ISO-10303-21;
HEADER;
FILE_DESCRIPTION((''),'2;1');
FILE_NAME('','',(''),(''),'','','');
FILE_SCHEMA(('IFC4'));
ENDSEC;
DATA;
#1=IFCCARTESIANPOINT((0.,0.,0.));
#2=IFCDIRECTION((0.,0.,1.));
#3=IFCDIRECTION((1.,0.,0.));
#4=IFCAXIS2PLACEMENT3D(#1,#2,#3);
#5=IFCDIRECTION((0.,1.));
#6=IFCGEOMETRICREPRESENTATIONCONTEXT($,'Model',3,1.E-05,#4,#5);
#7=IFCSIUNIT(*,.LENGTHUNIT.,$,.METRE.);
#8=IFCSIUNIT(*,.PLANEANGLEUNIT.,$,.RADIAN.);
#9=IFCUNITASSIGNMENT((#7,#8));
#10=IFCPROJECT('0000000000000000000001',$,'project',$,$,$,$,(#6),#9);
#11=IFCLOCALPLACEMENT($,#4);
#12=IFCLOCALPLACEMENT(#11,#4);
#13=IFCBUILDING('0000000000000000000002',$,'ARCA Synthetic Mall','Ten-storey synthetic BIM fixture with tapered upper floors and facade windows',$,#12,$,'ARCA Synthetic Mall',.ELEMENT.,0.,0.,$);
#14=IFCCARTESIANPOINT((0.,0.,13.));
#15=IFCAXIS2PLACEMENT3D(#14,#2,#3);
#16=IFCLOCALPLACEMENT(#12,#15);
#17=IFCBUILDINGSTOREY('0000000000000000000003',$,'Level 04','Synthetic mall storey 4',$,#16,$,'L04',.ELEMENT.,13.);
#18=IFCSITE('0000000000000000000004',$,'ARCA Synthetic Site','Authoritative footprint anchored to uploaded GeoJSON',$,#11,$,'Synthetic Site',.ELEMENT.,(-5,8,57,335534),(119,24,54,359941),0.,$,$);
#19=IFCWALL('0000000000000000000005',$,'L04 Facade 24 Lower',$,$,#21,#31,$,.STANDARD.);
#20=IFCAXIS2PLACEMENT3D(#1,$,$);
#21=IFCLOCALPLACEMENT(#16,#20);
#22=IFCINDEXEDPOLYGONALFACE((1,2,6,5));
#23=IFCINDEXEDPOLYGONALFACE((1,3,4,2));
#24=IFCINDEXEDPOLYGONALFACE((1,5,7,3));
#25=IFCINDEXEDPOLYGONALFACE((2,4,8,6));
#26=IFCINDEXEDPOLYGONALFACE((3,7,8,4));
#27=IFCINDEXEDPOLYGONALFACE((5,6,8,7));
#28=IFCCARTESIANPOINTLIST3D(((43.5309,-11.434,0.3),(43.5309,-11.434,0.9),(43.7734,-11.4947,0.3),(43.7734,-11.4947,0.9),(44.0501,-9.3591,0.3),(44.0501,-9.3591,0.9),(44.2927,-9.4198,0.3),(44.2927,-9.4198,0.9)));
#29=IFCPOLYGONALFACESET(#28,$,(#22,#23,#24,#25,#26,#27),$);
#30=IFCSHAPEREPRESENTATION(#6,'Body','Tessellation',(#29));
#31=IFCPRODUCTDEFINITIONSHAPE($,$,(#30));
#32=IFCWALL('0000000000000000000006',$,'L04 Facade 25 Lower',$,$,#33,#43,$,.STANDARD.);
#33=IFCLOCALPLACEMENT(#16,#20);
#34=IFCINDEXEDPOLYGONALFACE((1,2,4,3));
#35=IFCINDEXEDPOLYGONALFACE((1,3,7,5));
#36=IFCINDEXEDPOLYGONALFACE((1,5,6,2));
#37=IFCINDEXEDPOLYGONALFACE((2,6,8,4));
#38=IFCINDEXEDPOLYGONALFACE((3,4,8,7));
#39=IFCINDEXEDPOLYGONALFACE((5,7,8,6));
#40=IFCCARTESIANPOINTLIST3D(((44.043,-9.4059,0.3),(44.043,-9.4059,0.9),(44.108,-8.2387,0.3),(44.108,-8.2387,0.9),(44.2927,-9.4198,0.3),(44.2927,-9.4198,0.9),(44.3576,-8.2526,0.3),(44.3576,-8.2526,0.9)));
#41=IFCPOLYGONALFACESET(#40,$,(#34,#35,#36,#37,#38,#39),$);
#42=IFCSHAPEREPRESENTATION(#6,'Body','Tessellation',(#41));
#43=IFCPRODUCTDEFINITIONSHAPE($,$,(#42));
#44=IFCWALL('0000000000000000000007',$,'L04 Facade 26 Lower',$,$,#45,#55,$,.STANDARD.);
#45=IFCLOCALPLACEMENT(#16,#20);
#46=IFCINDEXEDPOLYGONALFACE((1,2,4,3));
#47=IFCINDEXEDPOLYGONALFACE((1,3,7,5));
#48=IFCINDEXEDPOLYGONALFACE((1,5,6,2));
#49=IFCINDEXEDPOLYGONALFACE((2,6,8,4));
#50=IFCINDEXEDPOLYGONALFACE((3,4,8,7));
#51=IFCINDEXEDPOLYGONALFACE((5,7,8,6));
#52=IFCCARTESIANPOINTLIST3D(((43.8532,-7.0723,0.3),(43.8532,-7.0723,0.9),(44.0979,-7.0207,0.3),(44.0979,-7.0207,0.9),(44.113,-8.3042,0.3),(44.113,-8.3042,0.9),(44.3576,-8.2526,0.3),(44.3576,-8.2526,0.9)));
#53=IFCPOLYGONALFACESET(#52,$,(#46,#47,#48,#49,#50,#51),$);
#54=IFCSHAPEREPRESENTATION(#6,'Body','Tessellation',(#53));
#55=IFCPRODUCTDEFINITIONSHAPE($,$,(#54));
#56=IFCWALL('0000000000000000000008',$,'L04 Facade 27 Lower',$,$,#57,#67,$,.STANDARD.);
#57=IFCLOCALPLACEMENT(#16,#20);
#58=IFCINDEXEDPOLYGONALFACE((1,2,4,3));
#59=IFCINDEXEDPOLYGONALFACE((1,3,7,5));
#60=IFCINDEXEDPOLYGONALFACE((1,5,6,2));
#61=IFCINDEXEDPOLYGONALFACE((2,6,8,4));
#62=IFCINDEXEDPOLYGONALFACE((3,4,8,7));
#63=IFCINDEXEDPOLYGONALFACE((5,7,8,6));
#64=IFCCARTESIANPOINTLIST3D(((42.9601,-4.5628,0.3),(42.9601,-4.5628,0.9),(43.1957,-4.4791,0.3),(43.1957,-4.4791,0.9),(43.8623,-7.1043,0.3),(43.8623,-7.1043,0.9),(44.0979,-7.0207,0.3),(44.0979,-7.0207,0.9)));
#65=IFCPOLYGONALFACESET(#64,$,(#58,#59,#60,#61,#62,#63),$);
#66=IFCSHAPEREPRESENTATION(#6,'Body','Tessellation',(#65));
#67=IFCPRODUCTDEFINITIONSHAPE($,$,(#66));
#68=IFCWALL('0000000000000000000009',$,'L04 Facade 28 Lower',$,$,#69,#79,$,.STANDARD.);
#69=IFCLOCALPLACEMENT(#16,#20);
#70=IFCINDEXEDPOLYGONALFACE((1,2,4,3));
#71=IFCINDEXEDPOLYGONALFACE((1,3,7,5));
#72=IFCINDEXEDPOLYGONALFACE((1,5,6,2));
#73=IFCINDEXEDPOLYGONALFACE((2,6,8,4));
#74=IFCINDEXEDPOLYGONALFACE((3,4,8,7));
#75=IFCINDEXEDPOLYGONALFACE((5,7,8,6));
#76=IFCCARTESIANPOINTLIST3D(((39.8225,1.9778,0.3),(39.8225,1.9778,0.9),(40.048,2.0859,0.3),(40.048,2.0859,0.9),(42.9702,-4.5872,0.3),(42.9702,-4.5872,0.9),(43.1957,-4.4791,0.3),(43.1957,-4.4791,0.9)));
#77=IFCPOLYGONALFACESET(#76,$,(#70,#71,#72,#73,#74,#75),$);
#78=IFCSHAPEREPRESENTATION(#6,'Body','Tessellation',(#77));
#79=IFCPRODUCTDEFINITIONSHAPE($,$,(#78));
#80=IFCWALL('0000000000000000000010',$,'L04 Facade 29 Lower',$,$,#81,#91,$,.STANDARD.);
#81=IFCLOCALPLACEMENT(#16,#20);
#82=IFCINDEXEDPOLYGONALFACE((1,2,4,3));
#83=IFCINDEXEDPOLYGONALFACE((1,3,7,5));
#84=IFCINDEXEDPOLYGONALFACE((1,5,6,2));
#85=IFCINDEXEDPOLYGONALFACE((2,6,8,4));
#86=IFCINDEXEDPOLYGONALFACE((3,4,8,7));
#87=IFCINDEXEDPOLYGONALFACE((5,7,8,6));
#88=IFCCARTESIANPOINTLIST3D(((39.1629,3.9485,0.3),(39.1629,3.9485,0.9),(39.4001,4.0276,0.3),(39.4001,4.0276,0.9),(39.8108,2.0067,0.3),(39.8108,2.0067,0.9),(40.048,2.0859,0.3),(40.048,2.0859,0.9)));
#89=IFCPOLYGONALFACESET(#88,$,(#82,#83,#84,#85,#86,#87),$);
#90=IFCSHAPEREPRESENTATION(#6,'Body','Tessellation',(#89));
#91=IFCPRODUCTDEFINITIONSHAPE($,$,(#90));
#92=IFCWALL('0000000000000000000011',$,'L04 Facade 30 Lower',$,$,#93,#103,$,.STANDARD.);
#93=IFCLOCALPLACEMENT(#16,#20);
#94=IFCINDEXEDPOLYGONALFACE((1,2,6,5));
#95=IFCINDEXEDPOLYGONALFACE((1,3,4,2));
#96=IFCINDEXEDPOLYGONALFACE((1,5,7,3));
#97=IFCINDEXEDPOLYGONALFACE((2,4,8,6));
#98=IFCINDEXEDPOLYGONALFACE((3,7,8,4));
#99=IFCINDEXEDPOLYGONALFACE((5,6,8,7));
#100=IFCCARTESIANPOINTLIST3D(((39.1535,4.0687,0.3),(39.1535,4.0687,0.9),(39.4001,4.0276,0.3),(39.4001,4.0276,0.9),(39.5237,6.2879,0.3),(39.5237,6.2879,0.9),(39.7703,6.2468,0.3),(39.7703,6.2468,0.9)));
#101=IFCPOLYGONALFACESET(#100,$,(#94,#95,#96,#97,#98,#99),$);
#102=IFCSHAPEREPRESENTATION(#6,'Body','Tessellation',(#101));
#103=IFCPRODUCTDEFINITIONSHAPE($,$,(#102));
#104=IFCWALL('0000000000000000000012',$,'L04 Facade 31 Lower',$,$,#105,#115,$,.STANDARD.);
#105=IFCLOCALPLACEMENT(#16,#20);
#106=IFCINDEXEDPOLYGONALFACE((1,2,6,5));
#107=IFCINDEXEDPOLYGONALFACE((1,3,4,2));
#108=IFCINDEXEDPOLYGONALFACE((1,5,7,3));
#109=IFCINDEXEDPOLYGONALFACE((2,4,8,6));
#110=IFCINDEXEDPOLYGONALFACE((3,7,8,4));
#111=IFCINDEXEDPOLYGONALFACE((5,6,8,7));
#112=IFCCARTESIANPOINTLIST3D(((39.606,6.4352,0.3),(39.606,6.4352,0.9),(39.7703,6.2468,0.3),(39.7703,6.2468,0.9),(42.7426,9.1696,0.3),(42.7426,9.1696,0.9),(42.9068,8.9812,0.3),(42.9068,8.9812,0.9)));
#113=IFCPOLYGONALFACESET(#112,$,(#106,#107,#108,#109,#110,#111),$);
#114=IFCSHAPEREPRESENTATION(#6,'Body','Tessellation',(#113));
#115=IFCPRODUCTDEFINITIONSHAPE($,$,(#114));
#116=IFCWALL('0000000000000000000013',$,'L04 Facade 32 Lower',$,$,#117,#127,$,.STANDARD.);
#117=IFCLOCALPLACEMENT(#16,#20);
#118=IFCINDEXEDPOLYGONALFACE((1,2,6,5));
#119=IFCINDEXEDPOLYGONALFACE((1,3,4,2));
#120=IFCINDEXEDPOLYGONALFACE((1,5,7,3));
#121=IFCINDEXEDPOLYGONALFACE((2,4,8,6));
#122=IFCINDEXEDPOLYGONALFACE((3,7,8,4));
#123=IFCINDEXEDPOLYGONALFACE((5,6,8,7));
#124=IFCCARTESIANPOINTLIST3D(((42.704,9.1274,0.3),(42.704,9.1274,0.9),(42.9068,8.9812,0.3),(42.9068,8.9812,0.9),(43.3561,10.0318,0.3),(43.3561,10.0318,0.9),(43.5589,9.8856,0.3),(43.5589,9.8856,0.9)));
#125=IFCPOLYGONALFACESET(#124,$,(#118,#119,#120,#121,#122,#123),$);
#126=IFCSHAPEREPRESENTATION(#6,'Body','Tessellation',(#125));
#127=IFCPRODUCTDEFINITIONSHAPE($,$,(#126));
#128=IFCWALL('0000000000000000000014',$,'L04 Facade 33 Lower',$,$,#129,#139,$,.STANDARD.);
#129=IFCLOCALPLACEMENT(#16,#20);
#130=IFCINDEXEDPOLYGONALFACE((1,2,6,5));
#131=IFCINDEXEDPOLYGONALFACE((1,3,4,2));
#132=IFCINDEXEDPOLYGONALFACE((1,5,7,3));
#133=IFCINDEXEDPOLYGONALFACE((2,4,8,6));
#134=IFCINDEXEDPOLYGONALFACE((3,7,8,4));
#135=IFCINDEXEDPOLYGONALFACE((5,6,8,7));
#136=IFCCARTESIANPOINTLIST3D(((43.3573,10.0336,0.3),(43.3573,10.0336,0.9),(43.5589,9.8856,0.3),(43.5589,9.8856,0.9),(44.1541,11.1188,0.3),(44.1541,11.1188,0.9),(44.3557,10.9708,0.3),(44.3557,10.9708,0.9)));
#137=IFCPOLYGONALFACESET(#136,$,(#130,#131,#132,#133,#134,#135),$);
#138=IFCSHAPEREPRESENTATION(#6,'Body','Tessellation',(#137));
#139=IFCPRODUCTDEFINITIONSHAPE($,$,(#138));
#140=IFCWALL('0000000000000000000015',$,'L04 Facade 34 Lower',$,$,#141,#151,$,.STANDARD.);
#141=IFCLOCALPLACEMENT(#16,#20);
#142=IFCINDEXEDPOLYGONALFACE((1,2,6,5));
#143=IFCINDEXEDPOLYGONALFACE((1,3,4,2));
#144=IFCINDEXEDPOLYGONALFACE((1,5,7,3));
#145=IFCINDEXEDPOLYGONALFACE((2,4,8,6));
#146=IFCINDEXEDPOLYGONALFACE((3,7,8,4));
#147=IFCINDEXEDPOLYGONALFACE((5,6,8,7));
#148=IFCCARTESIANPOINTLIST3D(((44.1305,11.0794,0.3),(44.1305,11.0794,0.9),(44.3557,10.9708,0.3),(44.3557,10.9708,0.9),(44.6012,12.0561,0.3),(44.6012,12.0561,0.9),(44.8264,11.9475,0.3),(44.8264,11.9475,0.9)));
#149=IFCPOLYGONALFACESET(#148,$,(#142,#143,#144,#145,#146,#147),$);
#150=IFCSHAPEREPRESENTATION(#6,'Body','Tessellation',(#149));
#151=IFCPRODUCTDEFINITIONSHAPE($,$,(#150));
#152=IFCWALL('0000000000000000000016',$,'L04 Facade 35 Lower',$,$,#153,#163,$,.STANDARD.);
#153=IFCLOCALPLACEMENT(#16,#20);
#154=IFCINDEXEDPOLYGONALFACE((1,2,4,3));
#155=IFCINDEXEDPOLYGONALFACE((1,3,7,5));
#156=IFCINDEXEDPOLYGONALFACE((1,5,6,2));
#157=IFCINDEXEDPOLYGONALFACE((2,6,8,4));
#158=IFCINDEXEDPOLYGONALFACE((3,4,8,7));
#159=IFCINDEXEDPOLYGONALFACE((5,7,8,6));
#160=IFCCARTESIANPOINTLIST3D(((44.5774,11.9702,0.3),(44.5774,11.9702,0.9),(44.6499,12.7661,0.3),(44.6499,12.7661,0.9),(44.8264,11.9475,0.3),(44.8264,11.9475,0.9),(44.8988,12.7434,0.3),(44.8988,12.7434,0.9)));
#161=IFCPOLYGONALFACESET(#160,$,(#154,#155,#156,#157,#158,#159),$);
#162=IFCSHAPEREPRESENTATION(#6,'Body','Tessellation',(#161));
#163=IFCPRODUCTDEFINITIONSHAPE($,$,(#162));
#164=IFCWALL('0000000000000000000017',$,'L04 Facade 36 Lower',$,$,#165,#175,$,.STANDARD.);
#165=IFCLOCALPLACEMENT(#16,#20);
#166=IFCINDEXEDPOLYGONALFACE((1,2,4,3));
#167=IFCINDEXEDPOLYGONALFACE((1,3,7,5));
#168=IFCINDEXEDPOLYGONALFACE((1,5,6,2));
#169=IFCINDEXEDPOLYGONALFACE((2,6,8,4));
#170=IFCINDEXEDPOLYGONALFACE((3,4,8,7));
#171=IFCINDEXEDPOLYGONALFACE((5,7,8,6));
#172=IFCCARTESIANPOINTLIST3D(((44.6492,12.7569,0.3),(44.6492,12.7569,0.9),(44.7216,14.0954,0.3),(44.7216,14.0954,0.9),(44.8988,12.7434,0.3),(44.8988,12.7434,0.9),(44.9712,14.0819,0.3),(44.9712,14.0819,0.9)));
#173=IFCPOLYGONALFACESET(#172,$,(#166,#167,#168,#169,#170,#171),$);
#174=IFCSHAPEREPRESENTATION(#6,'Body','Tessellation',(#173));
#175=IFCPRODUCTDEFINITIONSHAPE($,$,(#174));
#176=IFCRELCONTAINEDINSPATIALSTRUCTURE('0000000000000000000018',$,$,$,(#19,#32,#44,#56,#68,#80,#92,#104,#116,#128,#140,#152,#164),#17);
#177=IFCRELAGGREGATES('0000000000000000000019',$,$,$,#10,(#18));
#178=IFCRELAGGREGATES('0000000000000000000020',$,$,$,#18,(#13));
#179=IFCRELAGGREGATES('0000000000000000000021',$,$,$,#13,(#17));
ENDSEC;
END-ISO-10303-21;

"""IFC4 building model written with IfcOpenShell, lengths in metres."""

from ifc_helpers import new_model, si_unit, direction, frame, origin_with_axes, place, context, project, spatial, polyline, outline, extrude, element, save


model = new_model("IFC4")

# Units and contexts
model_context = context("Model", 3, precision=1e-05, world=origin_with_axes(), true_north=direction((0.0, 1.0)))
ifc_project = project(units=[si_unit("LENGTHUNIT", "METRE"), si_unit("PLANEANGLEUNIT", "RADIAN")], contexts=[model_context])

# Site, building, storey
site_placement = place(None, origin_with_axes())
site = spatial("IfcSite", under=ifc_project, at=site_placement, Name="ARCA Synthetic Site", Description="Authoritative footprint anchored to uploaded GeoJSON", LongName="Synthetic Site", CompositionType="ELEMENT", RefLatitude=(-5, 8, 57, 335534), RefLongitude=(119, 24, 54, 359941), RefElevation=0.0)
building_placement = place(site_placement, origin_with_axes())
building = spatial("IfcBuilding", under=site, at=building_placement, Name="ARCA Synthetic Mall", Description="Ten-storey synthetic BIM fixture with tapered upper floors and facade windows", LongName="ARCA Synthetic Mall", CompositionType="ELEMENT", ElevationOfRefHeight=0.0, ElevationOfTerrain=0.0)
storey_placement = place(building_placement, frame((0.0, 0.0, 13.0), z_axis=(0.0, 0.0, 1.0), x_axis=(1.0, 0.0, 0.0)))
storey = spatial("IfcBuildingStorey", under=building, at=storey_placement, Name="Level 04", Description="Synthetic mall storey 4", LongName="L04", CompositionType="ELEMENT", Elevation=13.0)

# Walls
wall_1_placement = place(storey_placement, frame((0.0, 0.0, 0.3), z_axis=(0.0, 0.0, 1.0), x_axis=(1.0, 0.0, 0.0)))
element("IfcWall", 1, at=wall_1_placement, inside=storey, Name="L04 Facade 24 Lower", PredefinedType="STANDARD", context=model_context, shape_type="SweptSolid", body=[
    extrude(outline(polyline([(43.7734, -11.4947), (44.2927, -9.4198), (44.0501, -9.3591), (43.5309, -11.434), (43.7734, -11.4947)])), origin_with_axes(), (0.0, 0.0, 1.0), 0.6),
])
wall_2_placement = place(storey_placement, frame((0.0, 0.0, 0.3), z_axis=(0.0, 0.0, 1.0), x_axis=(1.0, 0.0, 0.0)))
element("IfcWall", 2, at=wall_2_placement, inside=storey, Name="L04 Facade 25 Lower", PredefinedType="STANDARD", context=model_context, shape_type="SweptSolid", body=[
    extrude(outline(polyline([(44.2927, -9.4198), (44.3576, -8.2526), (44.108, -8.2387), (44.043, -9.4059), (44.2927, -9.4198)])), origin_with_axes(), (0.0, 0.0, 1.0), 0.6),
])
wall_3_placement = place(storey_placement, frame((0.0, 0.0, 0.3), z_axis=(0.0, 0.0, 1.0), x_axis=(1.0, 0.0, 0.0)))
element("IfcWall", 3, at=wall_3_placement, inside=storey, Name="L04 Facade 26 Lower", PredefinedType="STANDARD", context=model_context, shape_type="SweptSolid", body=[
    extrude(outline(polyline([(44.3576, -8.2526), (44.0979, -7.0207), (43.8532, -7.0723), (44.113, -8.3042), (44.3576, -8.2526)])), origin_with_axes(), (0.0, 0.0, 1.0), 0.6),
])
wall_4_placement = place(storey_placement, frame((0.0, 0.0, 0.3), z_axis=(0.0, 0.0, 1.0), x_axis=(1.0, 0.0, 0.0)))
element("IfcWall", 4, at=wall_4_placement, inside=storey, Name="L04 Facade 27 Lower", PredefinedType="STANDARD", context=model_context, shape_type="SweptSolid", body=[
    extrude(outline(polyline([(44.0979, -7.0207), (43.1957, -4.4791), (42.9601, -4.5628), (43.8623, -7.1043), (44.0979, -7.0207)])), origin_with_axes(), (0.0, 0.0, 1.0), 0.6),
])
wall_5_placement = place(storey_placement, frame((0.0, 0.0, 0.3), z_axis=(0.0, 0.0, 1.0), x_axis=(1.0, 0.0, 0.0)))
element("IfcWall", 5, at=wall_5_placement, inside=storey, Name="L04 Facade 28 Lower", PredefinedType="STANDARD", context=model_context, shape_type="SweptSolid", body=[
    extrude(outline(polyline([(43.1957, -4.4791), (40.048, 2.0859), (39.8225, 1.9778), (42.9702, -4.5872), (43.1957, -4.4791)])), origin_with_axes(), (0.0, 0.0, 1.0), 0.6),
])
wall_6_placement = place(storey_placement, frame((0.0, 0.0, 0.3), z_axis=(0.0, 0.0, 1.0), x_axis=(1.0, 0.0, 0.0)))
element("IfcWall", 6, at=wall_6_placement, inside=storey, Name="L04 Facade 29 Lower", PredefinedType="STANDARD", context=model_context, shape_type="SweptSolid", body=[
    extrude(outline(polyline([(40.048, 2.0859), (39.4001, 4.0276), (39.1629, 3.9485), (39.8108, 2.0067), (40.048, 2.0859)])), origin_with_axes(), (0.0, 0.0, 1.0), 0.6),
])
wall_7_placement = place(storey_placement, frame((0.0, 0.0, 0.3), z_axis=(0.0, 0.0, 1.0), x_axis=(1.0, 0.0, 0.0)))
element("IfcWall", 7, at=wall_7_placement, inside=storey, Name="L04 Facade 30 Lower", PredefinedType="STANDARD", context=model_context, shape_type="SweptSolid", body=[
    extrude(outline(polyline([(39.4001, 4.0276), (39.7703, 6.2468), (39.5237, 6.2879), (39.1535, 4.0687), (39.4001, 4.0276)])), origin_with_axes(), (0.0, 0.0, 1.0), 0.6),
])
wall_8_placement = place(storey_placement, frame((0.0, 0.0, 0.3), z_axis=(0.0, 0.0, 1.0), x_axis=(1.0, 0.0, 0.0)))
element("IfcWall", 8, at=wall_8_placement, inside=storey, Name="L04 Facade 31 Lower", PredefinedType="STANDARD", context=model_context, shape_type="SweptSolid", body=[
    extrude(outline(polyline([(39.7703, 6.2468), (42.9068, 8.9812), (42.7426, 9.1696), (39.606, 6.4352), (39.7703, 6.2468)])), origin_with_axes(), (0.0, 0.0, 1.0), 0.6),
])
wall_9_placement = place(storey_placement, frame((0.0, 0.0, 0.3), z_axis=(0.0, 0.0, 1.0), x_axis=(1.0, 0.0, 0.0)))
element("IfcWall", 9, at=wall_9_placement, inside=storey, Name="L04 Facade 32 Lower", PredefinedType="STANDARD", context=model_context, shape_type="SweptSolid", body=[
    extrude(outline(polyline([(42.9068, 8.9812), (43.5589, 9.8856), (43.3561, 10.0318), (42.704, 9.1274), (42.9068, 8.9812)])), origin_with_axes(), (0.0, 0.0, 1.0), 0.6),
])
wall_10_placement = place(storey_placement, frame((0.0, 0.0, 0.3), z_axis=(0.0, 0.0, 1.0), x_axis=(1.0, 0.0, 0.0)))
element("IfcWall", 10, at=wall_10_placement, inside=storey, Name="L04 Facade 33 Lower", PredefinedType="STANDARD", context=model_context, shape_type="SweptSolid", body=[
    extrude(outline(polyline([(43.5589, 9.8856), (44.3557, 10.9708), (44.1541, 11.1188), (43.3573, 10.0336), (43.5589, 9.8856)])), origin_with_axes(), (0.0, 0.0, 1.0), 0.6),
])
wall_11_placement = place(storey_placement, frame((0.0, 0.0, 0.3), z_axis=(0.0, 0.0, 1.0), x_axis=(1.0, 0.0, 0.0)))
element("IfcWall", 11, at=wall_11_placement, inside=storey, Name="L04 Facade 34 Lower", PredefinedType="STANDARD", context=model_context, shape_type="SweptSolid", body=[
    extrude(outline(polyline([(44.3557, 10.9708), (44.8264, 11.9475), (44.6012, 12.0561), (44.1305, 11.0794), (44.3557, 10.9708)])), origin_with_axes(), (0.0, 0.0, 1.0), 0.6),
])
wall_12_placement = place(storey_placement, frame((0.0, 0.0, 0.3), z_axis=(0.0, 0.0, 1.0), x_axis=(1.0, 0.0, 0.0)))
element("IfcWall", 12, at=wall_12_placement, inside=storey, Name="L04 Facade 35 Lower", PredefinedType="STANDARD", context=model_context, shape_type="SweptSolid", body=[
    extrude(outline(polyline([(44.8264, 11.9475), (44.8988, 12.7434), (44.6499, 12.7661), (44.5774, 11.9702), (44.8264, 11.9475)])), origin_with_axes(), (0.0, 0.0, 1.0), 0.6),
])
wall_13_placement = place(storey_placement, frame((0.0, 0.0, 0.3), z_axis=(0.0, 0.0, 1.0), x_axis=(1.0, 0.0, 0.0)))
element("IfcWall", 13, at=wall_13_placement, inside=storey, Name="L04 Facade 36 Lower", PredefinedType="STANDARD", context=model_context, shape_type="SweptSolid", body=[
    extrude(outline(polyline([(44.8988, 12.7434), (44.9712, 14.0819), (44.7216, 14.0954), (44.6492, 12.7569), (44.8988, 12.7434)])), origin_with_axes(), (0.0, 0.0, 1.0), 0.6),
])

save(model, "model.ifc")
